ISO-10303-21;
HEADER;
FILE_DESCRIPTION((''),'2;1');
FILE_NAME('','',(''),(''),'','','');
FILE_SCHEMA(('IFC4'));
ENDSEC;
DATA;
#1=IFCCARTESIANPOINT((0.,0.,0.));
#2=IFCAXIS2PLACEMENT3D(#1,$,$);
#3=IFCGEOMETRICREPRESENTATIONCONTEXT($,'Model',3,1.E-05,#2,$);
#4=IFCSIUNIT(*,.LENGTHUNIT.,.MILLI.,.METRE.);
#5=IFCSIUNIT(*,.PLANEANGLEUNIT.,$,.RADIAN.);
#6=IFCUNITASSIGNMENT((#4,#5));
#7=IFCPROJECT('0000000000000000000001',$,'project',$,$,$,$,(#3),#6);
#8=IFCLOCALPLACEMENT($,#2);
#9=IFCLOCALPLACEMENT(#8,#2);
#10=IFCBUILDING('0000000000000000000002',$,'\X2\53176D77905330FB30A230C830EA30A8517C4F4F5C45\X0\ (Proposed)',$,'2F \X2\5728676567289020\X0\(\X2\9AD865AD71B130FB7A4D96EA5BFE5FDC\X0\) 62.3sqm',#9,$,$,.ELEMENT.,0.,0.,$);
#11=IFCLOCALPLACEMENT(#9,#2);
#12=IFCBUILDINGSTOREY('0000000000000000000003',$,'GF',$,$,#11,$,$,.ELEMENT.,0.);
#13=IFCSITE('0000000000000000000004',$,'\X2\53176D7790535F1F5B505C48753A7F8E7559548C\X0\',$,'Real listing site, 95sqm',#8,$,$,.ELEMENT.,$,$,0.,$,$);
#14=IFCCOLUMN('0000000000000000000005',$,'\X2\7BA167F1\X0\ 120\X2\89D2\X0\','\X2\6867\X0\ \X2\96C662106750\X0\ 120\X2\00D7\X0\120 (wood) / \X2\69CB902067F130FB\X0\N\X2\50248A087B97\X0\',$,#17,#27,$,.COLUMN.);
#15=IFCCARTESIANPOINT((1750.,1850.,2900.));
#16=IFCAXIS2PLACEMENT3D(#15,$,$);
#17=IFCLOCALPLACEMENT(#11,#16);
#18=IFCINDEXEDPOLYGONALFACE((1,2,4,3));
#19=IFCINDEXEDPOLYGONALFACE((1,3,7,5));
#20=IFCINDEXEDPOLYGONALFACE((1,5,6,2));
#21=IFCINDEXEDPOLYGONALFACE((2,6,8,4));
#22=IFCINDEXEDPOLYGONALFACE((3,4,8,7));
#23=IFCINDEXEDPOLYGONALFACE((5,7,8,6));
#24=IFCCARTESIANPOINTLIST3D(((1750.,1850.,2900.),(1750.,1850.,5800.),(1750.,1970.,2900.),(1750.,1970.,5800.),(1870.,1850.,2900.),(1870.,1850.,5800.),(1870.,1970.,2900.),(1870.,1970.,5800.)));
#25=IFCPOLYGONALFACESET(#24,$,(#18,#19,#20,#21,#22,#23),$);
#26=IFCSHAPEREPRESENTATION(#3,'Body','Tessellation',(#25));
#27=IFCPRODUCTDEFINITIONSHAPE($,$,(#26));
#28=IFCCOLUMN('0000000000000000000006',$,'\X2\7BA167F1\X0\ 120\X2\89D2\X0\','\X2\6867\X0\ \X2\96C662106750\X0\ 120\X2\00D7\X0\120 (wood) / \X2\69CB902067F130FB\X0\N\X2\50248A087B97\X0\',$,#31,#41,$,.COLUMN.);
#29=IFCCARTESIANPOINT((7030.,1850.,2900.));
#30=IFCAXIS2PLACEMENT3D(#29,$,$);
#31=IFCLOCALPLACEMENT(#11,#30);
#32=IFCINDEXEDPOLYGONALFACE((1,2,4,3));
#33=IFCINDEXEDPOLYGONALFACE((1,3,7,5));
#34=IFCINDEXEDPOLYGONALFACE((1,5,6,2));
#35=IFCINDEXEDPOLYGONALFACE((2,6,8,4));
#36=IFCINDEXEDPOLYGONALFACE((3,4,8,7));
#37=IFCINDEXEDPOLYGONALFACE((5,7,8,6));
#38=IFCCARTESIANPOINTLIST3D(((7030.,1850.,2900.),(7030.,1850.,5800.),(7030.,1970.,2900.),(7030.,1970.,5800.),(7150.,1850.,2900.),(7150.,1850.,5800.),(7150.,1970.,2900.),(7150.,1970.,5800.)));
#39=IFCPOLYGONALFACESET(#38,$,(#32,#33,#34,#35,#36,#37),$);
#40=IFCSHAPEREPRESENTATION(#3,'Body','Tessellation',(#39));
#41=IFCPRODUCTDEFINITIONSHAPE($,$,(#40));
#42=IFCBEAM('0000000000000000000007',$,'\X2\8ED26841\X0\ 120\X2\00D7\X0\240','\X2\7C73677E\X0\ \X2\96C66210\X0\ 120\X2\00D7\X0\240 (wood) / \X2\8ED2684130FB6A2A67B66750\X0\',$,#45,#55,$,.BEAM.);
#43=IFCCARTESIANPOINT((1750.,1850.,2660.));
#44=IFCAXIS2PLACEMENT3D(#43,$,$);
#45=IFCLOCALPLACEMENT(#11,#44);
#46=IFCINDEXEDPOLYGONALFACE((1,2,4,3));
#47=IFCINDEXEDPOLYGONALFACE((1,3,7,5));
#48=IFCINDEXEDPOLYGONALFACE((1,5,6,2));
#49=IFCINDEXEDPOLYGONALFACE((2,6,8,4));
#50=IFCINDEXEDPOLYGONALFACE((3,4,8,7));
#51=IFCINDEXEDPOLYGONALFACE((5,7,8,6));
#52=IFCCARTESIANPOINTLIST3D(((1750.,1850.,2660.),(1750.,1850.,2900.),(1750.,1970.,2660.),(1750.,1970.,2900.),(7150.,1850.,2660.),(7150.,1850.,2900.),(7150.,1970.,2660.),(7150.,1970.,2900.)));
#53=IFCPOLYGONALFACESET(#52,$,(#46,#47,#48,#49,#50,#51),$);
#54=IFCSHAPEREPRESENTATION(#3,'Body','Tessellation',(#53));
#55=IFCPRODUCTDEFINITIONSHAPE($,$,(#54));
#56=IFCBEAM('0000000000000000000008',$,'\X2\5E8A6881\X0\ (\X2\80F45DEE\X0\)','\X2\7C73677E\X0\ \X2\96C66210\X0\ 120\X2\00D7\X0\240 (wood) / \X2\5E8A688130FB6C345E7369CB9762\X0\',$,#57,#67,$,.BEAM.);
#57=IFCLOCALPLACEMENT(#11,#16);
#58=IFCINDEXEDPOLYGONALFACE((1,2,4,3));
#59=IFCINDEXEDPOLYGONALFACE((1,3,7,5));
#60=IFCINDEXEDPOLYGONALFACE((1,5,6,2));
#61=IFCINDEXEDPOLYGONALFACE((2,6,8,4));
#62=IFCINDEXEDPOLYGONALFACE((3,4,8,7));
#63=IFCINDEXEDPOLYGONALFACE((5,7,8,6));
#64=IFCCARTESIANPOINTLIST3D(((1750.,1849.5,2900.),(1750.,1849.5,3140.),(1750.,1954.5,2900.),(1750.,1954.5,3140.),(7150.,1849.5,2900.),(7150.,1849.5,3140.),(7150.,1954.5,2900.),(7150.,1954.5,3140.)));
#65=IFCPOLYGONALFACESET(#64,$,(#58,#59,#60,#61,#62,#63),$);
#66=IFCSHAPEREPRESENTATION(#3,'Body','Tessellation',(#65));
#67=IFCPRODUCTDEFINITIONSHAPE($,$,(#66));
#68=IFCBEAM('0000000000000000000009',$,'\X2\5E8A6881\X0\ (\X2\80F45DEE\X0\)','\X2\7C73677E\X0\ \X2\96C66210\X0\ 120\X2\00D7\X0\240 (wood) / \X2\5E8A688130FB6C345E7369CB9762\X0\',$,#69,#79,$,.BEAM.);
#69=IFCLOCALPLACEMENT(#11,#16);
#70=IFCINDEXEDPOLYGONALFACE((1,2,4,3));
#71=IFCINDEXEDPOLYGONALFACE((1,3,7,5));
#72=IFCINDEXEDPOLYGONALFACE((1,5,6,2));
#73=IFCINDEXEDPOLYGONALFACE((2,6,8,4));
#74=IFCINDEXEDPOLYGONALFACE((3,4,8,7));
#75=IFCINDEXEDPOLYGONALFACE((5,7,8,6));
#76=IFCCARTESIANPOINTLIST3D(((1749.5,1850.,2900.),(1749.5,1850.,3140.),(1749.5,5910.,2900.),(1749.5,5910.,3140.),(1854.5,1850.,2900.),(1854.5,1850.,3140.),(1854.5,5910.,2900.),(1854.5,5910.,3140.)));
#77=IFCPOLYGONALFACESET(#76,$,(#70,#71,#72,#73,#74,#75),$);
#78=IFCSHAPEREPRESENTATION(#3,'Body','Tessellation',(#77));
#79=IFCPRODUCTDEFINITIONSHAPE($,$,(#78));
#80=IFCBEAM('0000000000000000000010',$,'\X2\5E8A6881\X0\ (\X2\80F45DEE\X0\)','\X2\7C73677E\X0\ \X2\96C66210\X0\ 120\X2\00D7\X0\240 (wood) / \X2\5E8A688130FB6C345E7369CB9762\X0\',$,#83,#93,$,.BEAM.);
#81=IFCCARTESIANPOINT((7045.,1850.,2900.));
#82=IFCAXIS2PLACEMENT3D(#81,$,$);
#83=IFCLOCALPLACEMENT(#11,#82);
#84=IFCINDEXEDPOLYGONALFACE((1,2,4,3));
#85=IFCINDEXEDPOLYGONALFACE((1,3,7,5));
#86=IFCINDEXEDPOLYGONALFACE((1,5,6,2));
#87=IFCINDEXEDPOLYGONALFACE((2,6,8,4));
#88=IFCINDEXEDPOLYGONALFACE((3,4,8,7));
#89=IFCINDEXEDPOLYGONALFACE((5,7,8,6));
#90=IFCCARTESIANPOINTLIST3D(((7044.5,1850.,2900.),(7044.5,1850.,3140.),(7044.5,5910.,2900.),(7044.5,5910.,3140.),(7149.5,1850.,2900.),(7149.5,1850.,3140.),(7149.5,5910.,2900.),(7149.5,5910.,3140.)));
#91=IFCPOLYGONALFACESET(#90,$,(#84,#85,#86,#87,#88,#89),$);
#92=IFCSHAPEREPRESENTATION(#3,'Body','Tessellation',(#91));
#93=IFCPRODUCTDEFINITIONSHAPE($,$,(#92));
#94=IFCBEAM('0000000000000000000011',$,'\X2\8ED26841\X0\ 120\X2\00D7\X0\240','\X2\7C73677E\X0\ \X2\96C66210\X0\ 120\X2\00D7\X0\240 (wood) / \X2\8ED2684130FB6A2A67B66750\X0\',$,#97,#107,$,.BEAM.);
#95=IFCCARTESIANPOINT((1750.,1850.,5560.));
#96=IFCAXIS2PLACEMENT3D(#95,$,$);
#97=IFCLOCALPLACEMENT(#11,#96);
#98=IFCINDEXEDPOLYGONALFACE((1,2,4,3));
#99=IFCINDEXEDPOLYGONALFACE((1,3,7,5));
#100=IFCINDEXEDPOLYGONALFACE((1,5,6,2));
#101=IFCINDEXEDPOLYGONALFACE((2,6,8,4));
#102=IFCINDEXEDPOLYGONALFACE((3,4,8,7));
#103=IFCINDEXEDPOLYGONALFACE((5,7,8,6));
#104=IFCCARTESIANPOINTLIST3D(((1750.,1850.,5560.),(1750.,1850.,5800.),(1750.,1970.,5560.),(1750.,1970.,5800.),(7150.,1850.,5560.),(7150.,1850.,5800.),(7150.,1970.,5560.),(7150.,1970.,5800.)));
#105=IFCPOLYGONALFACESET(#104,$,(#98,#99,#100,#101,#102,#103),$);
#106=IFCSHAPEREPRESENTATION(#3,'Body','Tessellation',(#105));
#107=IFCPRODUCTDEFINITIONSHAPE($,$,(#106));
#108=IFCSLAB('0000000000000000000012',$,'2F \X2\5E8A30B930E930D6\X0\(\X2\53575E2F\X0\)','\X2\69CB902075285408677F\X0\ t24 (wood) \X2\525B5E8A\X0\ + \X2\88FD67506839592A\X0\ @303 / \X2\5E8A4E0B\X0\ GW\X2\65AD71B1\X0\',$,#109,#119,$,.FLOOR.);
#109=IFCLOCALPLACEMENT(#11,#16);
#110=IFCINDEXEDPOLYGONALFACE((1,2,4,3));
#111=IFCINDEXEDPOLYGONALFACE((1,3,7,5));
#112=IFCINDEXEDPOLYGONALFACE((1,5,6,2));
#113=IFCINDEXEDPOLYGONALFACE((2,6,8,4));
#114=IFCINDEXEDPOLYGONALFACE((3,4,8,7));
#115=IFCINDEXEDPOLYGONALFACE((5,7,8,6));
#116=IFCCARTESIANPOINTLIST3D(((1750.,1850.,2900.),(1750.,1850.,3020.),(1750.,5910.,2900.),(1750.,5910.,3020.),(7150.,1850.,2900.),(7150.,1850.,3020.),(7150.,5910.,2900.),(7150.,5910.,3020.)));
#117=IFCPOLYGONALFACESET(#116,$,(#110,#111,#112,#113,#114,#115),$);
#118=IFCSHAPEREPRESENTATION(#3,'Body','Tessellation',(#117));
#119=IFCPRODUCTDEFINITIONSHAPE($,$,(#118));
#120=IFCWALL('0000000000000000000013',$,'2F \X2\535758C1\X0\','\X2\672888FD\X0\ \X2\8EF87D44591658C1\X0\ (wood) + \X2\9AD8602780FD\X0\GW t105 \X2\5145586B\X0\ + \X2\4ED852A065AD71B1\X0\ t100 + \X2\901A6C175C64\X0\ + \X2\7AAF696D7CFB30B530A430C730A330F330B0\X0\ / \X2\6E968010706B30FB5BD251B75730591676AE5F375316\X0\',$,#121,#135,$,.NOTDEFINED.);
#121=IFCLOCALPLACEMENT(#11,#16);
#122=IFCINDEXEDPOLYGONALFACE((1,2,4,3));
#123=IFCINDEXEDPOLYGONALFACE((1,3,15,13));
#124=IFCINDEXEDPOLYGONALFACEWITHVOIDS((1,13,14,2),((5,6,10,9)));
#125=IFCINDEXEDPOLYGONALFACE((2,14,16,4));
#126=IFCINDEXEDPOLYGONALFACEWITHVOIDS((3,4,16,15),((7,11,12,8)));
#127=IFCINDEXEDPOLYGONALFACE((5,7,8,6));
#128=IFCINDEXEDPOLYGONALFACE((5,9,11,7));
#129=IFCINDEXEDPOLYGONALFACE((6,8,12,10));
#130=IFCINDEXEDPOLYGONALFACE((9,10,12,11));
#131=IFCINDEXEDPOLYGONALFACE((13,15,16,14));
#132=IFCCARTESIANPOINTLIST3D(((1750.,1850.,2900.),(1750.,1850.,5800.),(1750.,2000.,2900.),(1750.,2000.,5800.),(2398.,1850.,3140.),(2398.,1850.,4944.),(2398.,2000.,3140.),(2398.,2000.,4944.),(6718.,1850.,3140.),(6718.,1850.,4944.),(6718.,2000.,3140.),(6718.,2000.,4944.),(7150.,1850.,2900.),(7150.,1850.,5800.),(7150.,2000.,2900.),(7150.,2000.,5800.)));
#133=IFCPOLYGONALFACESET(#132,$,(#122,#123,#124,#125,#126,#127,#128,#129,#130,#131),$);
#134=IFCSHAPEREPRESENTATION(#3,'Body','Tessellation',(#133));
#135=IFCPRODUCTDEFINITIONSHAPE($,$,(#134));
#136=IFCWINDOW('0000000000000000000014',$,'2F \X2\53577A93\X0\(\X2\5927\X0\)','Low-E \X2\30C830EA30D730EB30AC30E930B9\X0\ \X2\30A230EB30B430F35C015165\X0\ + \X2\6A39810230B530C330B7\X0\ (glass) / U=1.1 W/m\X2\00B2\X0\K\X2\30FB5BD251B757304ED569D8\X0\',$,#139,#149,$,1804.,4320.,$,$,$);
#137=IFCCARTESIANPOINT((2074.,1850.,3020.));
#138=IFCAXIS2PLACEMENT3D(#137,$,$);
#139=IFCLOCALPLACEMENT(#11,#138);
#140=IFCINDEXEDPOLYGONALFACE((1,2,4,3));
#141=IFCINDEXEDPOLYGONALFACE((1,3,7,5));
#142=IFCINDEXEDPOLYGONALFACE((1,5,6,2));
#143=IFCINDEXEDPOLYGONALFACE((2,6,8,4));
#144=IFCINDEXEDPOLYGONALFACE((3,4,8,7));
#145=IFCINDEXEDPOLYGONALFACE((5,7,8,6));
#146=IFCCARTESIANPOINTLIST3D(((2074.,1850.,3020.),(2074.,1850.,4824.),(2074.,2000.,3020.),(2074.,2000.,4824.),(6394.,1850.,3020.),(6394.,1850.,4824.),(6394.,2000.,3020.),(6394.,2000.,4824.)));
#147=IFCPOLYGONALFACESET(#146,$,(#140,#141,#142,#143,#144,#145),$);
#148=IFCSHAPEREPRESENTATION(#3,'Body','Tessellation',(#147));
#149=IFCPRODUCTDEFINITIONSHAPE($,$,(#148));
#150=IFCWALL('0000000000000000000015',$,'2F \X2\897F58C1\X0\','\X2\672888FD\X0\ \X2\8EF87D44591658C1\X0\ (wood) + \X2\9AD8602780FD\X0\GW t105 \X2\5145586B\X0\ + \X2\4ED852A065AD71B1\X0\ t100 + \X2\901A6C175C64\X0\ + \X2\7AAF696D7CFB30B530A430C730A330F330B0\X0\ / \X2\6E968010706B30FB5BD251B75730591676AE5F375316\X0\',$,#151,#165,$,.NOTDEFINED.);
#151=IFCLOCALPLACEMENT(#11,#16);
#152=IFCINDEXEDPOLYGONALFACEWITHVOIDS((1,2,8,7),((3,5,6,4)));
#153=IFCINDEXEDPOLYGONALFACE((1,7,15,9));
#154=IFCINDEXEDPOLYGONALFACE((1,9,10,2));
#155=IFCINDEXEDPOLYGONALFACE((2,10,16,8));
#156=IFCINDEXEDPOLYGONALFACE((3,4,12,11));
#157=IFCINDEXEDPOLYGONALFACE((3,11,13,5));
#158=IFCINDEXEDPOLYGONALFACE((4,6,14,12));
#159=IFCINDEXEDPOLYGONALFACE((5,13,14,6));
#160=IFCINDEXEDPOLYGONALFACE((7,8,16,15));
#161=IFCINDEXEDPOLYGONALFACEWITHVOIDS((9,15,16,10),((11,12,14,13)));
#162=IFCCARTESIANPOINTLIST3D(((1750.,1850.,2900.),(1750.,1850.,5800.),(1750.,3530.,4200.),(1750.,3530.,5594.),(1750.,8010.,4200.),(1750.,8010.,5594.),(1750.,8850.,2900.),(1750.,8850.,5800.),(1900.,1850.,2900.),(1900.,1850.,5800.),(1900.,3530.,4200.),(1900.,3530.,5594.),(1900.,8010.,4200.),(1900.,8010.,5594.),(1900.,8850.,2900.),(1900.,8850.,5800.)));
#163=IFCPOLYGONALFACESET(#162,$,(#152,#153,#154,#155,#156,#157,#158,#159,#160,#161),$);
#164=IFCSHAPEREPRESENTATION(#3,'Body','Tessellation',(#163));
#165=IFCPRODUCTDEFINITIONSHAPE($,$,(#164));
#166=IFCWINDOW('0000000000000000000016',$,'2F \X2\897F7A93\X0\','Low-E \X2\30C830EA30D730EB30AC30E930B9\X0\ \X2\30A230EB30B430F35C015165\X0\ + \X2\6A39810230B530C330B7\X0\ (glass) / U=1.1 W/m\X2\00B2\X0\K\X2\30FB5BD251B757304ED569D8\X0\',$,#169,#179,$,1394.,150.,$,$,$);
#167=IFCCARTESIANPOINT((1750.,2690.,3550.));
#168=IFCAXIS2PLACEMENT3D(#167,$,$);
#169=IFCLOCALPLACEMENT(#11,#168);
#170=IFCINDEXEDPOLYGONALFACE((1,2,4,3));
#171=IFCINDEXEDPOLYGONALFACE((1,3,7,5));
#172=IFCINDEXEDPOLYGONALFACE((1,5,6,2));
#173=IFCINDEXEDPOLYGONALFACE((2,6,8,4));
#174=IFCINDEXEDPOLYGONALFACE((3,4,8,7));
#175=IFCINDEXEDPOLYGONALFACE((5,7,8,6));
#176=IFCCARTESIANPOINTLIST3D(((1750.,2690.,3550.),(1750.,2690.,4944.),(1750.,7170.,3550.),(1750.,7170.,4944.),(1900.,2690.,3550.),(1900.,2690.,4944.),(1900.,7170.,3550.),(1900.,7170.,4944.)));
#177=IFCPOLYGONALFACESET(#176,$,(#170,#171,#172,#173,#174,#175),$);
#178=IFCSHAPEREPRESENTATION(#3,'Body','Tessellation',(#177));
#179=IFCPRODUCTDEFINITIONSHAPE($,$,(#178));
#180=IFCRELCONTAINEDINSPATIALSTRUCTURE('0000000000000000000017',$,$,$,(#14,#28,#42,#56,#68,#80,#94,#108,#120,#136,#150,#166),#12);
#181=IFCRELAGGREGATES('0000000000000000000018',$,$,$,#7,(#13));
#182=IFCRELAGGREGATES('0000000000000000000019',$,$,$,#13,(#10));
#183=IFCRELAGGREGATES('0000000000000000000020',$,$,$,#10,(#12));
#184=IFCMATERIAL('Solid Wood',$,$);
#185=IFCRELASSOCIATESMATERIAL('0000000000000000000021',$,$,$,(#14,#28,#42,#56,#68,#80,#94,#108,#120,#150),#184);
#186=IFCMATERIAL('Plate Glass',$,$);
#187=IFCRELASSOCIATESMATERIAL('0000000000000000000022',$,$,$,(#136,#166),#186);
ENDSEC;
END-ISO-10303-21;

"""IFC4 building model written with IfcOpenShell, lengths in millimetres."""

from ifc_helpers import new_model, si_unit, frame, frame_2d, origin, place, context, project, spatial, rectangle, extrude, material, element, fill, save


model = new_model("IFC4")

# Units and contexts
model_context = context("Model", 3, precision=1e-05, world=origin())
ifc_project = project(units=[si_unit("LENGTHUNIT", "METRE", prefix="MILLI"), si_unit("PLANEANGLEUNIT", "RADIAN")], contexts=[model_context])

# Site, building, storey
site_placement = place(None, origin())
site = spatial("IfcSite", under=ifc_project, at=site_placement, Name="北海道弟子屈町美留和", ObjectType="Real listing site, 95sqm", CompositionType="ELEMENT", RefElevation=0.0)
building_placement = place(site_placement, origin())
building = spatial("IfcBuilding", under=site, at=building_placement, Name="北海道・アトリエ兼住居 (Proposed)", ObjectType="2F 在来木造(高断熱・積雪対応) 62.3sqm", CompositionType="ELEMENT", ElevationOfRefHeight=0.0, ElevationOfTerrain=0.0)
storey_placement = place(building_placement, origin())
storey = spatial("IfcBuildingStorey", under=building, at=storey_placement, Name="GF", CompositionType="ELEMENT", Elevation=0.0)

# Columns
ifc_material_1 = material(Name="Solid Wood")
column_1_placement = place(storey_placement, frame((1750.0, 1850.0, 2900.0)))
element("IfcColumn", 1, at=column_1_placement, inside=storey, material=ifc_material_1, Name="管柱 120角", Description="桧 集成材 120×120 (wood) / 構造柱・N値計算", PredefinedType="COLUMN", context=model_context, shape_type="SweptSolid", body=[
    extrude(rectangle(XDim=120.0, YDim=120.0, at=frame_2d((60.0, 60.0))), frame((1750.0, 1850.0, 2900.0)), (0.0, 0.0, 1.0), 2900.0),
])
column_2_placement = place(storey_placement, frame((7030.0, 1850.0, 2900.0)))
element("IfcColumn", 2, at=column_2_placement, inside=storey, material=ifc_material_1, Name="管柱 120角", Description="桧 集成材 120×120 (wood) / 構造柱・N値計算", PredefinedType="COLUMN", context=model_context, shape_type="SweptSolid", body=[
    extrude(rectangle(XDim=120.0, YDim=120.0, at=frame_2d((60.0, 60.0))), frame((7030.0, 1850.0, 2900.0)), (0.0, 0.0, 1.0), 2900.0),
])

# Beams
beam_1_placement = place(storey_placement, frame((1750.0, 1850.0, 2660.0)))
element("IfcBeam", 3, at=beam_1_placement, inside=storey, material=ifc_material_1, Name="軒桁 120×240", Description="米松 集成 120×240 (wood) / 軒桁・横架材", PredefinedType="BEAM", context=model_context, shape_type="SweptSolid", body=[
    extrude(rectangle(XDim=5400.0, YDim=120.0, at=frame_2d((2700.0, 60.0))), frame((1750.0, 1850.0, 2660.0)), (0.0, 0.0, 1.0), 240.0),
])
beam_2_placement = place(storey_placement, frame((1750.0, 1850.0, 2900.0)))
element("IfcBeam", 4, at=beam_2_placement, inside=storey, material=ifc_material_1, Name="床梁 (胴差)", Description="米松 集成 120×240 (wood) / 床梁・水平構面", PredefinedType="BEAM", context=model_context, shape_type="SweptSolid", body=[
    extrude(rectangle(XDim=5400.0, YDim=105.0, at=frame_2d((2700.0, 52.0))), frame((1750.0, 1850.0, 2900.0)), (0.0, 0.0, 1.0), 240.0),
])
beam_3_placement = place(storey_placement, frame((1750.0, 1850.0, 2900.0)))
element("IfcBeam", 5, at=beam_3_placement, inside=storey, material=ifc_material_1, Name="床梁 (胴差)", Description="米松 集成 120×240 (wood) / 床梁・水平構面", PredefinedType="BEAM", context=model_context, shape_type="SweptSolid", body=[
    extrude(rectangle(XDim=105.0, YDim=4060.0, at=frame_2d((52.0, 2030.0))), frame((1750.0, 1850.0, 2900.0)), (0.0, 0.0, 1.0), 240.0),
])
beam_4_placement = place(storey_placement, frame((7045.0, 1850.0, 2900.0)))
element("IfcBeam", 6, at=beam_4_placement, inside=storey, material=ifc_material_1, Name="床梁 (胴差)", Description="米松 集成 120×240 (wood) / 床梁・水平構面", PredefinedType="BEAM", context=model_context, shape_type="SweptSolid", body=[
    extrude(rectangle(XDim=105.0, YDim=4060.0, at=frame_2d((52.0, 2030.0))), frame((7045.0, 1850.0, 2900.0)), (0.0, 0.0, 1.0), 240.0),
])
beam_5_placement = place(storey_placement, frame((1750.0, 1850.0, 5560.0)))
element("IfcBeam", 7, at=beam_5_placement, inside=storey, material=ifc_material_1, Name="軒桁 120×240", Description="米松 集成 120×240 (wood) / 軒桁・横架材", PredefinedType="BEAM", context=model_context, shape_type="SweptSolid", body=[
    extrude(rectangle(XDim=5400.0, YDim=120.0, at=frame_2d((2700.0, 60.0))), frame((1750.0, 1850.0, 5560.0)), (0.0, 0.0, 1.0), 240.0),
])

# Slab
slab_placement = place(storey_placement, frame((1750.0, 1850.0, 2900.0)))
element("IfcSlab", 8, at=slab_placement, inside=storey, material=ifc_material_1, Name="2F 床スラブ(南帯)", Description="構造用合板 t24 (wood) 剛床 + 製材根太 @303 / 床下 GW断熱", PredefinedType="FLOOR", context=model_context, shape_type="SweptSolid", body=[
    extrude(rectangle(XDim=5400.0, YDim=4060.0, at=frame_2d((2700.0, 2030.0))), frame((1750.0, 1850.0, 2900.0)), (0.0, 0.0, 1.0), 120.0),
])

# Walls, openings, windows
wall_1_placement = place(storey_placement, frame((1750.0, 1850.0, 2900.0)))
wall_1 = element("IfcWall", 9, at=wall_1_placement, inside=storey, material=ifc_material_1, Name="2F 南壁", Description="木製 軸組外壁 (wood) + 高性能GW t105 充填 + 付加断熱 t100 + 通気層 + 窯業系サイディング / 準耐火・寒冷地外皮強化", PredefinedType="NOTDEFINED", context=model_context, shape_type="SweptSolid", body=[
    extrude(rectangle(XDim=5400.0, YDim=150.0, at=frame_2d((2700.0, 75.0))), frame((1750.0, 1850.0, 2900.0)), (0.0, 0.0, 1.0), 2900.0),
])
opening_1_placement = place(storey_placement, frame((2074.0, 1850.0, 3020.0)))
opening_1 = element("IfcOpeningElement", 10, at=opening_1_placement, cuts=wall_1, PredefinedType="NOTDEFINED", context=model_context, shape_type="SweptSolid", body=[
    extrude(rectangle(XDim=4320.0, YDim=150.0, at=frame_2d((2160.0, 75.0))), frame((2074.0, 1850.0, 3020.0)), (0.0, 0.0, 1.0), 1804.0),
])
ifc_material_2 = material(Name="Plate Glass")
window_1_placement = place(storey_placement, frame((2074.0, 1850.0, 3020.0)))
window_1 = element("IfcWindow", 11, at=window_1_placement, inside=storey, material=ifc_material_2, Name="2F 南窓(大)", Description="Low-E トリプルガラス アルゴン封入 + 樹脂サッシ (glass) / U=1.1 W/m²K・寒冷地仕様", OverallHeight=1804.0, OverallWidth=4320.0, context=model_context, shape_type="SweptSolid", body=[
    extrude(rectangle(XDim=4320.0, YDim=150.0, at=frame_2d((2160.0, 75.0))), frame((2074.0, 1850.0, 3020.0)), (0.0, 0.0, 1.0), 1804.0),
])
fill(opening_1, window_1)
wall_2_placement = place(storey_placement, frame((1750.0, 1850.0, 2900.0)))
wall_2 = element("IfcWall", 12, at=wall_2_placement, inside=storey, material=ifc_material_1, Name="2F 西壁", Description="木製 軸組外壁 (wood) + 高性能GW t105 充填 + 付加断熱 t100 + 通気層 + 窯業系サイディング / 準耐火・寒冷地外皮強化", PredefinedType="NOTDEFINED", context=model_context, shape_type="SweptSolid", body=[
    extrude(rectangle(XDim=150.0, YDim=7000.0, at=frame_2d((75.0, 3500.0))), frame((1750.0, 1850.0, 2900.0)), (0.0, 0.0, 1.0), 2900.0),
])
opening_2_placement = place(storey_placement, frame((1750.0, 2690.0, 3550.0)))
opening_2 = element("IfcOpeningElement", 13, at=opening_2_placement, cuts=wall_2, PredefinedType="NOTDEFINED", context=model_context, shape_type="SweptSolid", body=[
    extrude(rectangle(XDim=150.0, YDim=4480.0, at=frame_2d((75.0, 2240.0))), frame((1750.0, 2690.0, 3550.0)), (0.0, 0.0, 1.0), 1394.0),
])
window_2_placement = place(storey_placement, frame((1750.0, 2690.0, 3550.0)))
window_2 = element("IfcWindow", 14, at=window_2_placement, inside=storey, material=ifc_material_2, Name="2F 西窓", Description="Low-E トリプルガラス アルゴン封入 + 樹脂サッシ (glass) / U=1.1 W/m²K・寒冷地仕様", OverallHeight=1394.0, OverallWidth=150.0, context=model_context, shape_type="SweptSolid", body=[
    extrude(rectangle(XDim=150.0, YDim=4480.0, at=frame_2d((75.0, 2240.0))), frame((1750.0, 2690.0, 3550.0)), (0.0, 0.0, 1.0), 1394.0),
])
fill(opening_2, window_2)

save(model, "model.ifc")
